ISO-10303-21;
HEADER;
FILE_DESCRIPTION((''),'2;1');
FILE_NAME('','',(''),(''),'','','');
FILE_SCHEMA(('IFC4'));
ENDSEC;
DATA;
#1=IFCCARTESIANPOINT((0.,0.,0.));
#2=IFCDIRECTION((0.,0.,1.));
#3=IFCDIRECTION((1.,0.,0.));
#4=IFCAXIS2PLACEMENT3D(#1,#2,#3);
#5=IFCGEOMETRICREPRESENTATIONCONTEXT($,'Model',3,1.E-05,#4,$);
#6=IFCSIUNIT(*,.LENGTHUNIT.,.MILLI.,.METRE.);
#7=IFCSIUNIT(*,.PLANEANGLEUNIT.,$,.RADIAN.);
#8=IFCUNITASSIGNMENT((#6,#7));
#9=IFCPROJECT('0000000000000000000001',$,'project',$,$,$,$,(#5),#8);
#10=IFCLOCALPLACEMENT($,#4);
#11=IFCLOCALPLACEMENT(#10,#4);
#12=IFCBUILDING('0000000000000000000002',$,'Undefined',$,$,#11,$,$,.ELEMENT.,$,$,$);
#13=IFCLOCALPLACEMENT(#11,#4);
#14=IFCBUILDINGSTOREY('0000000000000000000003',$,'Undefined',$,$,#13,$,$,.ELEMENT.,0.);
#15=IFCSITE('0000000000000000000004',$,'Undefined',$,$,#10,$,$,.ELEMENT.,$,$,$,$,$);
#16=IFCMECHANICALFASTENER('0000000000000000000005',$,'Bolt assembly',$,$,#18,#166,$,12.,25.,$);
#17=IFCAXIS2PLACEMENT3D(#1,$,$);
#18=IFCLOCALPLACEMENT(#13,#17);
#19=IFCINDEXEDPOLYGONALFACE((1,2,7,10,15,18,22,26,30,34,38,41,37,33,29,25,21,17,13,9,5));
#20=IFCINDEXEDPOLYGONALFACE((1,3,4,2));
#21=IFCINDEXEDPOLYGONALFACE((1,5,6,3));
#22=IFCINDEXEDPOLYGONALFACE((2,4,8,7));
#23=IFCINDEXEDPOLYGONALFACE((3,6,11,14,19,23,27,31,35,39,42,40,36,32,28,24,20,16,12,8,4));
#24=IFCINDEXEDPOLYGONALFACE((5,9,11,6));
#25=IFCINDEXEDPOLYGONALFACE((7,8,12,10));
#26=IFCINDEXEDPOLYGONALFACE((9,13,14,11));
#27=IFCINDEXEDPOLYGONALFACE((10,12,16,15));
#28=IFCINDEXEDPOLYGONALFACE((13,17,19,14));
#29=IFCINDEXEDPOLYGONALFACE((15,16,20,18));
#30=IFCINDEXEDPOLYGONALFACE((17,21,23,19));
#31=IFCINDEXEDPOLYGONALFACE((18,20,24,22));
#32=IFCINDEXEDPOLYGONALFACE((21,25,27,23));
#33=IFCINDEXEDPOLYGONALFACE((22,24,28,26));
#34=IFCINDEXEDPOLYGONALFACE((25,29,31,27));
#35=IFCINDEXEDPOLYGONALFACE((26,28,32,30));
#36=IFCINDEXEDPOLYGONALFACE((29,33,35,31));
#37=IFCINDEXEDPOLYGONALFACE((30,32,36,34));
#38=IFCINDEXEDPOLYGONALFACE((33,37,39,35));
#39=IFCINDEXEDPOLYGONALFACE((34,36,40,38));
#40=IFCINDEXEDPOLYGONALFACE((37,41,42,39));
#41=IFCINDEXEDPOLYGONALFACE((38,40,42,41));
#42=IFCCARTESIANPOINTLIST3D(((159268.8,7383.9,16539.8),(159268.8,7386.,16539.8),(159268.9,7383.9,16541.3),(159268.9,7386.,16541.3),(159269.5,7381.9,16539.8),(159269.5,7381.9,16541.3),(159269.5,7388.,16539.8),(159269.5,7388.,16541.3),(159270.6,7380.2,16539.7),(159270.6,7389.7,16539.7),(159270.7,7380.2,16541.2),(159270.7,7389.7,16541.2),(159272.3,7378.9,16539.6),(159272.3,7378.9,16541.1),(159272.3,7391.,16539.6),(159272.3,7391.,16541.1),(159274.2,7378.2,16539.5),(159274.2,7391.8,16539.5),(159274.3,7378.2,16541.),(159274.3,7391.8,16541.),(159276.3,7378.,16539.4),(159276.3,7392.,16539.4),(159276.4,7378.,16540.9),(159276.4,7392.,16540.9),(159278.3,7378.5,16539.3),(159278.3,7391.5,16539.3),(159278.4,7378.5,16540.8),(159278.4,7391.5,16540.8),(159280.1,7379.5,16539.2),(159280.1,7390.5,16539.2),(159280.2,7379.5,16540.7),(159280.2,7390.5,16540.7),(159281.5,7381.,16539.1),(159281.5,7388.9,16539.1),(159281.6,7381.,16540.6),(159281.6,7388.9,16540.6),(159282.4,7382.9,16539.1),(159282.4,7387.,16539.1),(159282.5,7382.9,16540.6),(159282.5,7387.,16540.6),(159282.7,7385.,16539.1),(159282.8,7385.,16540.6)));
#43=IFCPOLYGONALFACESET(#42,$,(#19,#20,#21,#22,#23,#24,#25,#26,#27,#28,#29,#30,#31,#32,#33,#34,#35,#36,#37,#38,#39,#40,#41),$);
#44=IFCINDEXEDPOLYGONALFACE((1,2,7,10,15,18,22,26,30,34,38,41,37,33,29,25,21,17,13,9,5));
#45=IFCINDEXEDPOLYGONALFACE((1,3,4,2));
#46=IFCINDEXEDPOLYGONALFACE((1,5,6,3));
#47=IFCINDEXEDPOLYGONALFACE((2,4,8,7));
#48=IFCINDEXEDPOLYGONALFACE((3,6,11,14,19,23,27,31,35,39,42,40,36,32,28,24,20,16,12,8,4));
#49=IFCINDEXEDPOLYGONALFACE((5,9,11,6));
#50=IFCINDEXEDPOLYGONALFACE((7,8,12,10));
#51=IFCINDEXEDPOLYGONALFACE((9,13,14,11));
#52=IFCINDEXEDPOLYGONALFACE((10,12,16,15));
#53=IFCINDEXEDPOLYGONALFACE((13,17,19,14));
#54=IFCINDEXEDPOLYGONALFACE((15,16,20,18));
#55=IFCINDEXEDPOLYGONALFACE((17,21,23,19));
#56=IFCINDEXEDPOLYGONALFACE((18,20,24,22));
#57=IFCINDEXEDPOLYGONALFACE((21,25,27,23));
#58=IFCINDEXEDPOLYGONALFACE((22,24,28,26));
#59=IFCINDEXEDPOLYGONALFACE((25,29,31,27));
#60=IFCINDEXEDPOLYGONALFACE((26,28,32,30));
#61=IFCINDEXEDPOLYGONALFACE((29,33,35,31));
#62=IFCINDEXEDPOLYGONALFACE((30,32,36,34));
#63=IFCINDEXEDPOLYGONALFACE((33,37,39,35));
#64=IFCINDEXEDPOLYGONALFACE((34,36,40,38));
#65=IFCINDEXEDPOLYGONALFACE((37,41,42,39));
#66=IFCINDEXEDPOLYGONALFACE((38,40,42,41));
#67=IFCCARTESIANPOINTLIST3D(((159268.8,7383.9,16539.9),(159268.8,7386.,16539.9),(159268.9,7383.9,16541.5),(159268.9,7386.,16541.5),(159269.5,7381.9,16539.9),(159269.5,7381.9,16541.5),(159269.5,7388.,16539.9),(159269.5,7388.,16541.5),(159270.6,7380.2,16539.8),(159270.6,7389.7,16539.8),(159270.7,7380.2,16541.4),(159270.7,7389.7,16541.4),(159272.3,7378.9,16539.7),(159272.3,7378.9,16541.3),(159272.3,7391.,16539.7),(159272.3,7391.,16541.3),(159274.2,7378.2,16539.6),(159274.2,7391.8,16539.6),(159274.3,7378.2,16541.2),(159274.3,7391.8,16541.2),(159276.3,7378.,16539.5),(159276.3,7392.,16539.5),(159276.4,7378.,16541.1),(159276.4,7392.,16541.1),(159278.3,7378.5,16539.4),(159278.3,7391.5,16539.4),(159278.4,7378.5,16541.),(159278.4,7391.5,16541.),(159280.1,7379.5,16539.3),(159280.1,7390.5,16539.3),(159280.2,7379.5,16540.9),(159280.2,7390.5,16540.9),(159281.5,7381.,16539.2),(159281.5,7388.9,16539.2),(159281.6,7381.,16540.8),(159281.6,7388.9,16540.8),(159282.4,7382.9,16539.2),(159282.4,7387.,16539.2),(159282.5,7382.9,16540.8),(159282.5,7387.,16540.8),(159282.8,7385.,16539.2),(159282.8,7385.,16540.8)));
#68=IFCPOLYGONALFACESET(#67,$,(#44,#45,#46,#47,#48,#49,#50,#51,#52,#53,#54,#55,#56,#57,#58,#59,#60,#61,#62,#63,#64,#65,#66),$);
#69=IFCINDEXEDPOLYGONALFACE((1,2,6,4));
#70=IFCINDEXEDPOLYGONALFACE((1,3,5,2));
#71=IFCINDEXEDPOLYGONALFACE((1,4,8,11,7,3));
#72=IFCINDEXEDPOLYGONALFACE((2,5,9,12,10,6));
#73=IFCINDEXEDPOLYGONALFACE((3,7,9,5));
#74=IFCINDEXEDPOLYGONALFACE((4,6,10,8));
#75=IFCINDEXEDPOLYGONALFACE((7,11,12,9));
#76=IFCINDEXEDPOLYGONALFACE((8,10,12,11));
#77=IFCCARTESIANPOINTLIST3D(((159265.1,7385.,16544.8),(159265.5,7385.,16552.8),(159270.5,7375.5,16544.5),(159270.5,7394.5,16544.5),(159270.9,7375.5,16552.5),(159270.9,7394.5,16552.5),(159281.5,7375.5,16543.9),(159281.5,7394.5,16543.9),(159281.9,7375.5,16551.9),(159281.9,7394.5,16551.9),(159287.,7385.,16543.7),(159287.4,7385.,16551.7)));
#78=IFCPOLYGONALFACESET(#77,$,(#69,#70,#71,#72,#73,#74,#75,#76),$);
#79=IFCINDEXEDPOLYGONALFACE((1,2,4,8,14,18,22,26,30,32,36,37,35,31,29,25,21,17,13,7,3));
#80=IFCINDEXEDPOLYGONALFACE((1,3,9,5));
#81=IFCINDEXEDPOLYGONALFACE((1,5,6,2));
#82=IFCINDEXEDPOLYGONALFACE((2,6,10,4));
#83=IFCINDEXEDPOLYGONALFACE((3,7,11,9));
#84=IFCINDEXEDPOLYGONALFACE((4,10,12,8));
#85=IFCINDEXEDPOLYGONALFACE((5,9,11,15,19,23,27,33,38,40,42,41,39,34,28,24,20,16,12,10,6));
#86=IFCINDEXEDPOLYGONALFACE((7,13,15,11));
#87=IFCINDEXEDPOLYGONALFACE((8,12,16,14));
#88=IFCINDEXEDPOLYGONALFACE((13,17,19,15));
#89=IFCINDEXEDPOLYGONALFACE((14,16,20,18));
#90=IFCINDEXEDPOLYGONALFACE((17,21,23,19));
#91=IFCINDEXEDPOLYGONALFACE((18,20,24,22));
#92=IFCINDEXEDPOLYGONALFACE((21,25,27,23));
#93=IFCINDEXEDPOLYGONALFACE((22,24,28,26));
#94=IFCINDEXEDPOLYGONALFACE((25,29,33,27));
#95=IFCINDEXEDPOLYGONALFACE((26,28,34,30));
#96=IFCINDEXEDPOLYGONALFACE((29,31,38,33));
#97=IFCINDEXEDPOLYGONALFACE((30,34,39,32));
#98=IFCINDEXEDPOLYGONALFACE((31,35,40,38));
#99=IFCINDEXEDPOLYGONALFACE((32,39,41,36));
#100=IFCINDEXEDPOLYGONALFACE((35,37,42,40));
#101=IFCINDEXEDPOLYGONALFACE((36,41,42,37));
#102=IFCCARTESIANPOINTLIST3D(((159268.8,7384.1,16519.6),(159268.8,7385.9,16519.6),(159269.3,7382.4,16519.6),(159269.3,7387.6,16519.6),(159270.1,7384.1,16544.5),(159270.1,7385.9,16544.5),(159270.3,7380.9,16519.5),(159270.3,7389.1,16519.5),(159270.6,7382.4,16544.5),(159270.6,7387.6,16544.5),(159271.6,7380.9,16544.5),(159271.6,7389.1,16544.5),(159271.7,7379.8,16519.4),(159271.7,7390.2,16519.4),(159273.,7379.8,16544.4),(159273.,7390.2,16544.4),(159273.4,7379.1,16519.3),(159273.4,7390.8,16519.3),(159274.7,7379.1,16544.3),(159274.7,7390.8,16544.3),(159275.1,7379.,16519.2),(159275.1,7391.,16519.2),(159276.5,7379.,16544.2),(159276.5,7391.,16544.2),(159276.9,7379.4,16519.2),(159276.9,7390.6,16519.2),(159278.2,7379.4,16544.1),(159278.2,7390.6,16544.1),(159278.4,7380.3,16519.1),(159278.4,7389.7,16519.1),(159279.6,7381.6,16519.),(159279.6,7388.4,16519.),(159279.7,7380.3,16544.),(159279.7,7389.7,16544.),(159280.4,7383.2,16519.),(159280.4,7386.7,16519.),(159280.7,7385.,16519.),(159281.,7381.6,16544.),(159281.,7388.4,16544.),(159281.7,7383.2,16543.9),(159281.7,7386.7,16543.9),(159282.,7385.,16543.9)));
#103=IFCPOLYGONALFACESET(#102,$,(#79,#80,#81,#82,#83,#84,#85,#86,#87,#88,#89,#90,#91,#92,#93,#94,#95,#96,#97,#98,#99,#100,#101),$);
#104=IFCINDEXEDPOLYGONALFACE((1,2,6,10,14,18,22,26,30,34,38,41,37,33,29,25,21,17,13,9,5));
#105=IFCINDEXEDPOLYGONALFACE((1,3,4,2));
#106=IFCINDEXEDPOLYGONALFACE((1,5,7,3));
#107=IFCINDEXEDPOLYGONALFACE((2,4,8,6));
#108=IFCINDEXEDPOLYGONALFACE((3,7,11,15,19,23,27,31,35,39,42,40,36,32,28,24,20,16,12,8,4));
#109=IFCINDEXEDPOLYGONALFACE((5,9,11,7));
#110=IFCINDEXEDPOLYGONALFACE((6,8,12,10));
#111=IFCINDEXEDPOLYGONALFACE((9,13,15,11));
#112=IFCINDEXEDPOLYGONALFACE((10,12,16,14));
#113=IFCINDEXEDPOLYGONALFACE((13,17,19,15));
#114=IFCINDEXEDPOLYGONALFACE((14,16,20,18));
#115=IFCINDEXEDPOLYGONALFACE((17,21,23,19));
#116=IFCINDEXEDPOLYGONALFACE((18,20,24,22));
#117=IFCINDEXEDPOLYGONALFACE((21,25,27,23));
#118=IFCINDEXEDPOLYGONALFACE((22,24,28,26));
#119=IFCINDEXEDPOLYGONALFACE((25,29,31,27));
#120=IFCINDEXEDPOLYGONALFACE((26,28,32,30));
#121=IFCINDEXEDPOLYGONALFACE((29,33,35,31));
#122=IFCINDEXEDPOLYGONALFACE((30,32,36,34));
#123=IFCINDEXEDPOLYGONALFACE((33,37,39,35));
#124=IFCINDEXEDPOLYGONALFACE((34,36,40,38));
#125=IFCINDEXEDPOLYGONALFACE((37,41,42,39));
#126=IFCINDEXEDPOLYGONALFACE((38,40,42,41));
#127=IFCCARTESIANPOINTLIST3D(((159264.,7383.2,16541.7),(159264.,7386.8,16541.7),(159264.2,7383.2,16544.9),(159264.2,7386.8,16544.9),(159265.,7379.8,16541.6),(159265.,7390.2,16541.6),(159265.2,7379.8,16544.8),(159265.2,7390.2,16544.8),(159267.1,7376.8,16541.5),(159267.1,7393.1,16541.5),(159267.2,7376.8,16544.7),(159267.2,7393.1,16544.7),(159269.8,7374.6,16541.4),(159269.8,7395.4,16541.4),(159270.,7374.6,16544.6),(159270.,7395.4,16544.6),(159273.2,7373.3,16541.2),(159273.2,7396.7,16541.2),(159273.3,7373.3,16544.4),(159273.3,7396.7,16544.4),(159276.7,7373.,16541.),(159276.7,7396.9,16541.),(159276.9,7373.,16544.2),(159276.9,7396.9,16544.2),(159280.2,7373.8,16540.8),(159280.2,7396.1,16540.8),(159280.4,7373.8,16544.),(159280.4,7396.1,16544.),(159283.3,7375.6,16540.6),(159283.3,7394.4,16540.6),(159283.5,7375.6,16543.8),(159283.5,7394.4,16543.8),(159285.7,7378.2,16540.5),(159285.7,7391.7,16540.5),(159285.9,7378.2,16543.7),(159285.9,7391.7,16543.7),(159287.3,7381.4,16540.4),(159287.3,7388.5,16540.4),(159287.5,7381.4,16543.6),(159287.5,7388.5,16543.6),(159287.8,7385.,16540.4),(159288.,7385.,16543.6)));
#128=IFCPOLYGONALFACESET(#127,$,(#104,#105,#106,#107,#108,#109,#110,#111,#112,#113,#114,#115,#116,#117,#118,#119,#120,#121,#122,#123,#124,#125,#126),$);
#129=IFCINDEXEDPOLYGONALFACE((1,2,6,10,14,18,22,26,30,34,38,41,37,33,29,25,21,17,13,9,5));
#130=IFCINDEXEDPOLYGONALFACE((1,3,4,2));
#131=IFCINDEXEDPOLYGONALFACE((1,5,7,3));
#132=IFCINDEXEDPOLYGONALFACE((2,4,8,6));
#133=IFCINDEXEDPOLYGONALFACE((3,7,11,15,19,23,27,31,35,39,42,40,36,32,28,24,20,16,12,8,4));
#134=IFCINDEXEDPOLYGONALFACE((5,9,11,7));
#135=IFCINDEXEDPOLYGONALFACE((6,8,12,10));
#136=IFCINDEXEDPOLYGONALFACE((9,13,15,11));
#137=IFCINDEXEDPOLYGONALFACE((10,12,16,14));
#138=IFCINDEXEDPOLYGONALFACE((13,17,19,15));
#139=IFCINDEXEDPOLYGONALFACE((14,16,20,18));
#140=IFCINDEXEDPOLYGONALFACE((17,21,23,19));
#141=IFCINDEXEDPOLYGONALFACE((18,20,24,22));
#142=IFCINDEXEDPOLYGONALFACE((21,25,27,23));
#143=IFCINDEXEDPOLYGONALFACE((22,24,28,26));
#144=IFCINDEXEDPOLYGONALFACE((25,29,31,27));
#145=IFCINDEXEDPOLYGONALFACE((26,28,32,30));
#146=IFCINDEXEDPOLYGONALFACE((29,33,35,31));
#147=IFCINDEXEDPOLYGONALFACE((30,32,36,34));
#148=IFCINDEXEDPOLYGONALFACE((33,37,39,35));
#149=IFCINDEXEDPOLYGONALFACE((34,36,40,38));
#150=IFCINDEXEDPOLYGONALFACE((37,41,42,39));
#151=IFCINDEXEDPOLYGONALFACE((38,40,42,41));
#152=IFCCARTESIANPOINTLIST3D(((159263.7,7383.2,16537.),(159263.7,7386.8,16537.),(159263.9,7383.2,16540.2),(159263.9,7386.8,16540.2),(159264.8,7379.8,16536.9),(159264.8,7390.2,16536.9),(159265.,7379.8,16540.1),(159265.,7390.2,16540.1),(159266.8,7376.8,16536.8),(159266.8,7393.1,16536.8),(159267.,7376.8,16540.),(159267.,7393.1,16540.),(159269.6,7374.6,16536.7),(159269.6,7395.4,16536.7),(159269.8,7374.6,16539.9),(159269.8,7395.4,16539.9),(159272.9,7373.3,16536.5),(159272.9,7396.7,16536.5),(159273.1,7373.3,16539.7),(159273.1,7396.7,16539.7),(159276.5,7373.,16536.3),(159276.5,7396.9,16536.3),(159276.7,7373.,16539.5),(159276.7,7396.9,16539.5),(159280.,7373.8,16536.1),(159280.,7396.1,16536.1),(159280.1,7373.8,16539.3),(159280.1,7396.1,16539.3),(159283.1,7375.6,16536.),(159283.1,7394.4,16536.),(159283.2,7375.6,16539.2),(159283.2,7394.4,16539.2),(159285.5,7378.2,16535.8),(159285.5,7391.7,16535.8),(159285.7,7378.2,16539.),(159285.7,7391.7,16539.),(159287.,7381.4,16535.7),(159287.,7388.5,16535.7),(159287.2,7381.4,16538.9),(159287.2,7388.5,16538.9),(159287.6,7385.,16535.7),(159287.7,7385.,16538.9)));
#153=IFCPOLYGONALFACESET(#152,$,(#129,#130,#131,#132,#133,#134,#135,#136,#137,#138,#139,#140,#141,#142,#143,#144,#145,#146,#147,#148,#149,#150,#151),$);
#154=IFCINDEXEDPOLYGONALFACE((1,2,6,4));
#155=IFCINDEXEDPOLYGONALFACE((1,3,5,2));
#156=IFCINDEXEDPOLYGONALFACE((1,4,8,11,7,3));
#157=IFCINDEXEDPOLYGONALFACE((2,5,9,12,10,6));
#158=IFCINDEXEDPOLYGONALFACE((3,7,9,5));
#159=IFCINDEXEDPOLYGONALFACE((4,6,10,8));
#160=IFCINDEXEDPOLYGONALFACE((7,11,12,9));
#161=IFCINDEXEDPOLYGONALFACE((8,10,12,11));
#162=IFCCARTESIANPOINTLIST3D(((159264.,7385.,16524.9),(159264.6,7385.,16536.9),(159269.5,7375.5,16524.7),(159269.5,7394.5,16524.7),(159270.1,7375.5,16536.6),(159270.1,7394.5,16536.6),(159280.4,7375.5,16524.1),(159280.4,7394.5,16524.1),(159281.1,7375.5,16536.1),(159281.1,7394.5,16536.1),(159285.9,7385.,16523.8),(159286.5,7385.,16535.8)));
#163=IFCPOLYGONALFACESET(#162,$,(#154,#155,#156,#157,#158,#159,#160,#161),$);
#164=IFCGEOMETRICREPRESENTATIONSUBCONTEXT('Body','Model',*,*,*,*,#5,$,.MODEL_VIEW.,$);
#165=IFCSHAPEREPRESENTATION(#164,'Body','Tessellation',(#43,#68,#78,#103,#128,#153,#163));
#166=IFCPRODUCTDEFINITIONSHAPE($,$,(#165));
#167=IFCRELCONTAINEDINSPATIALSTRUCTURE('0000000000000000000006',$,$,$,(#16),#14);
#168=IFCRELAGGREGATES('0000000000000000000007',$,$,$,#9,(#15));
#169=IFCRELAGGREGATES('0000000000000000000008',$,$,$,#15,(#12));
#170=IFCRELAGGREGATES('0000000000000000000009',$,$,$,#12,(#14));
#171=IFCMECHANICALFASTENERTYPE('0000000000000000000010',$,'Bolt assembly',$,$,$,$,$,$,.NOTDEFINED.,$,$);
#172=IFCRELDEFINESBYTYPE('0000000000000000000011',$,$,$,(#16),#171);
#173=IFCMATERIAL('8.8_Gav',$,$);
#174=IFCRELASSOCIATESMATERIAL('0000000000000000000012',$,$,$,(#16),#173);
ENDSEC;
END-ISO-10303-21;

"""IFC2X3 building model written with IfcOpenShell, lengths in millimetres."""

from ifc_helpers import new_model, si_unit, frame, origin_with_axes, origin_2d_with_axis, place, context, subcontext, project, spatial, polyline, circle, outline, extrude, source, transform, mapped, material, type_object, element, save


model = new_model("IFC2X3")

# Units and contexts
model_context = context("Model", 3, precision=1e-05, world=origin_with_axes())
body_context = subcontext(model_context, "Body", "Model", "MODEL_VIEW")
ifc_project = project(units=[si_unit("LENGTHUNIT", "METRE", prefix="MILLI"), si_unit("PLANEANGLEUNIT", "RADIAN")], contexts=[model_context])

# Site, building, storey
site_placement = place(None, origin_with_axes())
site = spatial("IfcSite", under=ifc_project, at=site_placement, Name="Undefined", CompositionType="ELEMENT")
building_placement = place(site_placement, origin_with_axes())
building = spatial("IfcBuilding", under=site, at=building_placement, Name="Undefined", CompositionType="ELEMENT")
storey_placement = place(building_placement, origin_with_axes())
storey = spatial("IfcBuildingStorey", under=building, at=storey_placement, Name="Undefined", CompositionType="ELEMENT", Elevation=0.0)

# Mechanical fastener
mechanical_fastener_type = type_object("IfcMechanicalFastenerType", Name="Bolt assembly")
ifc_material_1 = material(Name="8.8_Gav")
shared_shape_1 = source(origin_with_axes(), body_context, "Body", "SweptSolid", [
    extrude(circle(Radius=7.0, at=origin_2d_with_axis()), frame((0.0, -0.4, 0.0), z_axis=(0.0, 1.0, 0.0), x_axis=(1.0, 0.0, 0.0)), (0.0, 0.0, 1.0), 1.5),
    extrude(circle(Radius=7.0, at=origin_2d_with_axis()), frame((0.0, -0.6, 0.0), z_axis=(0.0, 1.0, 0.0), x_axis=(1.0, 0.0, 0.0)), (0.0, 0.0, 1.0), 1.6),
    extrude(outline(polyline([(11.0, 0.0), (5.5, 9.5), (-5.5, 9.5), (-11.0, 0.0), (-5.5, -9.5), (5.5, -9.5), (11.0, 0.0)])), frame((0.0, -11.7, 0.0), z_axis=(0.0, 1.0, 0.0), x_axis=(1.0, 0.0, 0.0)), (0.0, 0.0, 1.0), 8.0),
    extrude(circle(Radius=6.0, at=origin_2d_with_axis()), frame((0.0, -3.7, 0.0), z_axis=(0.0, 1.0, 0.0), x_axis=(1.0, 0.0, 0.0)), (0.0, 0.0, 1.0), 25.0),
    extrude(circle(Radius=12.0, at=origin_2d_with_axis()), frame((0.0, -3.7, 0.0), z_axis=(0.0, 1.0, 0.0), x_axis=(1.0, 0.0, 0.0)), (0.0, 0.0, 1.0), 3.2),
    extrude(circle(Radius=12.0, at=origin_2d_with_axis()), frame((0.0, 1.0, 0.0), z_axis=(0.0, 1.0, 0.0), x_axis=(1.0, 0.0, 0.0)), (0.0, 0.0, 1.0), 3.2),
    extrude(outline(polyline([(11.0, 0.0), (5.5, 9.5), (-5.5, 9.5), (-11.0, 0.0), (-5.5, -9.5), (5.5, -9.5), (11.0, 0.0)])), frame((0.0, 4.2, 0.0), z_axis=(0.0, 1.0, 0.0), x_axis=(1.0, 0.0, 0.0)), (0.0, 0.0, 1.0), 12.0),
])
for number, where, z_axis, x_axis, name in (
    (1, (159275.8, 7385.0, 16540.5), (0.0, 1.0, 0.0), (0.998627, 0.0, -0.052392), "Bolt assembly"),
):
    element("IfcMechanicalFastener", number, at=place(storey_placement, frame(where, z_axis=z_axis, x_axis=x_axis)), inside=storey, type_object=mechanical_fastener_type, material=ifc_material_1, Name=name, NominalDiameter=12.0, NominalLength=25.0, context=body_context, shape_type="MappedRepresentation", body=[
        mapped(shared_shape_1, transform((0.0, 0.0, 0.0))),
    ])

save(model, "model.ifc")
